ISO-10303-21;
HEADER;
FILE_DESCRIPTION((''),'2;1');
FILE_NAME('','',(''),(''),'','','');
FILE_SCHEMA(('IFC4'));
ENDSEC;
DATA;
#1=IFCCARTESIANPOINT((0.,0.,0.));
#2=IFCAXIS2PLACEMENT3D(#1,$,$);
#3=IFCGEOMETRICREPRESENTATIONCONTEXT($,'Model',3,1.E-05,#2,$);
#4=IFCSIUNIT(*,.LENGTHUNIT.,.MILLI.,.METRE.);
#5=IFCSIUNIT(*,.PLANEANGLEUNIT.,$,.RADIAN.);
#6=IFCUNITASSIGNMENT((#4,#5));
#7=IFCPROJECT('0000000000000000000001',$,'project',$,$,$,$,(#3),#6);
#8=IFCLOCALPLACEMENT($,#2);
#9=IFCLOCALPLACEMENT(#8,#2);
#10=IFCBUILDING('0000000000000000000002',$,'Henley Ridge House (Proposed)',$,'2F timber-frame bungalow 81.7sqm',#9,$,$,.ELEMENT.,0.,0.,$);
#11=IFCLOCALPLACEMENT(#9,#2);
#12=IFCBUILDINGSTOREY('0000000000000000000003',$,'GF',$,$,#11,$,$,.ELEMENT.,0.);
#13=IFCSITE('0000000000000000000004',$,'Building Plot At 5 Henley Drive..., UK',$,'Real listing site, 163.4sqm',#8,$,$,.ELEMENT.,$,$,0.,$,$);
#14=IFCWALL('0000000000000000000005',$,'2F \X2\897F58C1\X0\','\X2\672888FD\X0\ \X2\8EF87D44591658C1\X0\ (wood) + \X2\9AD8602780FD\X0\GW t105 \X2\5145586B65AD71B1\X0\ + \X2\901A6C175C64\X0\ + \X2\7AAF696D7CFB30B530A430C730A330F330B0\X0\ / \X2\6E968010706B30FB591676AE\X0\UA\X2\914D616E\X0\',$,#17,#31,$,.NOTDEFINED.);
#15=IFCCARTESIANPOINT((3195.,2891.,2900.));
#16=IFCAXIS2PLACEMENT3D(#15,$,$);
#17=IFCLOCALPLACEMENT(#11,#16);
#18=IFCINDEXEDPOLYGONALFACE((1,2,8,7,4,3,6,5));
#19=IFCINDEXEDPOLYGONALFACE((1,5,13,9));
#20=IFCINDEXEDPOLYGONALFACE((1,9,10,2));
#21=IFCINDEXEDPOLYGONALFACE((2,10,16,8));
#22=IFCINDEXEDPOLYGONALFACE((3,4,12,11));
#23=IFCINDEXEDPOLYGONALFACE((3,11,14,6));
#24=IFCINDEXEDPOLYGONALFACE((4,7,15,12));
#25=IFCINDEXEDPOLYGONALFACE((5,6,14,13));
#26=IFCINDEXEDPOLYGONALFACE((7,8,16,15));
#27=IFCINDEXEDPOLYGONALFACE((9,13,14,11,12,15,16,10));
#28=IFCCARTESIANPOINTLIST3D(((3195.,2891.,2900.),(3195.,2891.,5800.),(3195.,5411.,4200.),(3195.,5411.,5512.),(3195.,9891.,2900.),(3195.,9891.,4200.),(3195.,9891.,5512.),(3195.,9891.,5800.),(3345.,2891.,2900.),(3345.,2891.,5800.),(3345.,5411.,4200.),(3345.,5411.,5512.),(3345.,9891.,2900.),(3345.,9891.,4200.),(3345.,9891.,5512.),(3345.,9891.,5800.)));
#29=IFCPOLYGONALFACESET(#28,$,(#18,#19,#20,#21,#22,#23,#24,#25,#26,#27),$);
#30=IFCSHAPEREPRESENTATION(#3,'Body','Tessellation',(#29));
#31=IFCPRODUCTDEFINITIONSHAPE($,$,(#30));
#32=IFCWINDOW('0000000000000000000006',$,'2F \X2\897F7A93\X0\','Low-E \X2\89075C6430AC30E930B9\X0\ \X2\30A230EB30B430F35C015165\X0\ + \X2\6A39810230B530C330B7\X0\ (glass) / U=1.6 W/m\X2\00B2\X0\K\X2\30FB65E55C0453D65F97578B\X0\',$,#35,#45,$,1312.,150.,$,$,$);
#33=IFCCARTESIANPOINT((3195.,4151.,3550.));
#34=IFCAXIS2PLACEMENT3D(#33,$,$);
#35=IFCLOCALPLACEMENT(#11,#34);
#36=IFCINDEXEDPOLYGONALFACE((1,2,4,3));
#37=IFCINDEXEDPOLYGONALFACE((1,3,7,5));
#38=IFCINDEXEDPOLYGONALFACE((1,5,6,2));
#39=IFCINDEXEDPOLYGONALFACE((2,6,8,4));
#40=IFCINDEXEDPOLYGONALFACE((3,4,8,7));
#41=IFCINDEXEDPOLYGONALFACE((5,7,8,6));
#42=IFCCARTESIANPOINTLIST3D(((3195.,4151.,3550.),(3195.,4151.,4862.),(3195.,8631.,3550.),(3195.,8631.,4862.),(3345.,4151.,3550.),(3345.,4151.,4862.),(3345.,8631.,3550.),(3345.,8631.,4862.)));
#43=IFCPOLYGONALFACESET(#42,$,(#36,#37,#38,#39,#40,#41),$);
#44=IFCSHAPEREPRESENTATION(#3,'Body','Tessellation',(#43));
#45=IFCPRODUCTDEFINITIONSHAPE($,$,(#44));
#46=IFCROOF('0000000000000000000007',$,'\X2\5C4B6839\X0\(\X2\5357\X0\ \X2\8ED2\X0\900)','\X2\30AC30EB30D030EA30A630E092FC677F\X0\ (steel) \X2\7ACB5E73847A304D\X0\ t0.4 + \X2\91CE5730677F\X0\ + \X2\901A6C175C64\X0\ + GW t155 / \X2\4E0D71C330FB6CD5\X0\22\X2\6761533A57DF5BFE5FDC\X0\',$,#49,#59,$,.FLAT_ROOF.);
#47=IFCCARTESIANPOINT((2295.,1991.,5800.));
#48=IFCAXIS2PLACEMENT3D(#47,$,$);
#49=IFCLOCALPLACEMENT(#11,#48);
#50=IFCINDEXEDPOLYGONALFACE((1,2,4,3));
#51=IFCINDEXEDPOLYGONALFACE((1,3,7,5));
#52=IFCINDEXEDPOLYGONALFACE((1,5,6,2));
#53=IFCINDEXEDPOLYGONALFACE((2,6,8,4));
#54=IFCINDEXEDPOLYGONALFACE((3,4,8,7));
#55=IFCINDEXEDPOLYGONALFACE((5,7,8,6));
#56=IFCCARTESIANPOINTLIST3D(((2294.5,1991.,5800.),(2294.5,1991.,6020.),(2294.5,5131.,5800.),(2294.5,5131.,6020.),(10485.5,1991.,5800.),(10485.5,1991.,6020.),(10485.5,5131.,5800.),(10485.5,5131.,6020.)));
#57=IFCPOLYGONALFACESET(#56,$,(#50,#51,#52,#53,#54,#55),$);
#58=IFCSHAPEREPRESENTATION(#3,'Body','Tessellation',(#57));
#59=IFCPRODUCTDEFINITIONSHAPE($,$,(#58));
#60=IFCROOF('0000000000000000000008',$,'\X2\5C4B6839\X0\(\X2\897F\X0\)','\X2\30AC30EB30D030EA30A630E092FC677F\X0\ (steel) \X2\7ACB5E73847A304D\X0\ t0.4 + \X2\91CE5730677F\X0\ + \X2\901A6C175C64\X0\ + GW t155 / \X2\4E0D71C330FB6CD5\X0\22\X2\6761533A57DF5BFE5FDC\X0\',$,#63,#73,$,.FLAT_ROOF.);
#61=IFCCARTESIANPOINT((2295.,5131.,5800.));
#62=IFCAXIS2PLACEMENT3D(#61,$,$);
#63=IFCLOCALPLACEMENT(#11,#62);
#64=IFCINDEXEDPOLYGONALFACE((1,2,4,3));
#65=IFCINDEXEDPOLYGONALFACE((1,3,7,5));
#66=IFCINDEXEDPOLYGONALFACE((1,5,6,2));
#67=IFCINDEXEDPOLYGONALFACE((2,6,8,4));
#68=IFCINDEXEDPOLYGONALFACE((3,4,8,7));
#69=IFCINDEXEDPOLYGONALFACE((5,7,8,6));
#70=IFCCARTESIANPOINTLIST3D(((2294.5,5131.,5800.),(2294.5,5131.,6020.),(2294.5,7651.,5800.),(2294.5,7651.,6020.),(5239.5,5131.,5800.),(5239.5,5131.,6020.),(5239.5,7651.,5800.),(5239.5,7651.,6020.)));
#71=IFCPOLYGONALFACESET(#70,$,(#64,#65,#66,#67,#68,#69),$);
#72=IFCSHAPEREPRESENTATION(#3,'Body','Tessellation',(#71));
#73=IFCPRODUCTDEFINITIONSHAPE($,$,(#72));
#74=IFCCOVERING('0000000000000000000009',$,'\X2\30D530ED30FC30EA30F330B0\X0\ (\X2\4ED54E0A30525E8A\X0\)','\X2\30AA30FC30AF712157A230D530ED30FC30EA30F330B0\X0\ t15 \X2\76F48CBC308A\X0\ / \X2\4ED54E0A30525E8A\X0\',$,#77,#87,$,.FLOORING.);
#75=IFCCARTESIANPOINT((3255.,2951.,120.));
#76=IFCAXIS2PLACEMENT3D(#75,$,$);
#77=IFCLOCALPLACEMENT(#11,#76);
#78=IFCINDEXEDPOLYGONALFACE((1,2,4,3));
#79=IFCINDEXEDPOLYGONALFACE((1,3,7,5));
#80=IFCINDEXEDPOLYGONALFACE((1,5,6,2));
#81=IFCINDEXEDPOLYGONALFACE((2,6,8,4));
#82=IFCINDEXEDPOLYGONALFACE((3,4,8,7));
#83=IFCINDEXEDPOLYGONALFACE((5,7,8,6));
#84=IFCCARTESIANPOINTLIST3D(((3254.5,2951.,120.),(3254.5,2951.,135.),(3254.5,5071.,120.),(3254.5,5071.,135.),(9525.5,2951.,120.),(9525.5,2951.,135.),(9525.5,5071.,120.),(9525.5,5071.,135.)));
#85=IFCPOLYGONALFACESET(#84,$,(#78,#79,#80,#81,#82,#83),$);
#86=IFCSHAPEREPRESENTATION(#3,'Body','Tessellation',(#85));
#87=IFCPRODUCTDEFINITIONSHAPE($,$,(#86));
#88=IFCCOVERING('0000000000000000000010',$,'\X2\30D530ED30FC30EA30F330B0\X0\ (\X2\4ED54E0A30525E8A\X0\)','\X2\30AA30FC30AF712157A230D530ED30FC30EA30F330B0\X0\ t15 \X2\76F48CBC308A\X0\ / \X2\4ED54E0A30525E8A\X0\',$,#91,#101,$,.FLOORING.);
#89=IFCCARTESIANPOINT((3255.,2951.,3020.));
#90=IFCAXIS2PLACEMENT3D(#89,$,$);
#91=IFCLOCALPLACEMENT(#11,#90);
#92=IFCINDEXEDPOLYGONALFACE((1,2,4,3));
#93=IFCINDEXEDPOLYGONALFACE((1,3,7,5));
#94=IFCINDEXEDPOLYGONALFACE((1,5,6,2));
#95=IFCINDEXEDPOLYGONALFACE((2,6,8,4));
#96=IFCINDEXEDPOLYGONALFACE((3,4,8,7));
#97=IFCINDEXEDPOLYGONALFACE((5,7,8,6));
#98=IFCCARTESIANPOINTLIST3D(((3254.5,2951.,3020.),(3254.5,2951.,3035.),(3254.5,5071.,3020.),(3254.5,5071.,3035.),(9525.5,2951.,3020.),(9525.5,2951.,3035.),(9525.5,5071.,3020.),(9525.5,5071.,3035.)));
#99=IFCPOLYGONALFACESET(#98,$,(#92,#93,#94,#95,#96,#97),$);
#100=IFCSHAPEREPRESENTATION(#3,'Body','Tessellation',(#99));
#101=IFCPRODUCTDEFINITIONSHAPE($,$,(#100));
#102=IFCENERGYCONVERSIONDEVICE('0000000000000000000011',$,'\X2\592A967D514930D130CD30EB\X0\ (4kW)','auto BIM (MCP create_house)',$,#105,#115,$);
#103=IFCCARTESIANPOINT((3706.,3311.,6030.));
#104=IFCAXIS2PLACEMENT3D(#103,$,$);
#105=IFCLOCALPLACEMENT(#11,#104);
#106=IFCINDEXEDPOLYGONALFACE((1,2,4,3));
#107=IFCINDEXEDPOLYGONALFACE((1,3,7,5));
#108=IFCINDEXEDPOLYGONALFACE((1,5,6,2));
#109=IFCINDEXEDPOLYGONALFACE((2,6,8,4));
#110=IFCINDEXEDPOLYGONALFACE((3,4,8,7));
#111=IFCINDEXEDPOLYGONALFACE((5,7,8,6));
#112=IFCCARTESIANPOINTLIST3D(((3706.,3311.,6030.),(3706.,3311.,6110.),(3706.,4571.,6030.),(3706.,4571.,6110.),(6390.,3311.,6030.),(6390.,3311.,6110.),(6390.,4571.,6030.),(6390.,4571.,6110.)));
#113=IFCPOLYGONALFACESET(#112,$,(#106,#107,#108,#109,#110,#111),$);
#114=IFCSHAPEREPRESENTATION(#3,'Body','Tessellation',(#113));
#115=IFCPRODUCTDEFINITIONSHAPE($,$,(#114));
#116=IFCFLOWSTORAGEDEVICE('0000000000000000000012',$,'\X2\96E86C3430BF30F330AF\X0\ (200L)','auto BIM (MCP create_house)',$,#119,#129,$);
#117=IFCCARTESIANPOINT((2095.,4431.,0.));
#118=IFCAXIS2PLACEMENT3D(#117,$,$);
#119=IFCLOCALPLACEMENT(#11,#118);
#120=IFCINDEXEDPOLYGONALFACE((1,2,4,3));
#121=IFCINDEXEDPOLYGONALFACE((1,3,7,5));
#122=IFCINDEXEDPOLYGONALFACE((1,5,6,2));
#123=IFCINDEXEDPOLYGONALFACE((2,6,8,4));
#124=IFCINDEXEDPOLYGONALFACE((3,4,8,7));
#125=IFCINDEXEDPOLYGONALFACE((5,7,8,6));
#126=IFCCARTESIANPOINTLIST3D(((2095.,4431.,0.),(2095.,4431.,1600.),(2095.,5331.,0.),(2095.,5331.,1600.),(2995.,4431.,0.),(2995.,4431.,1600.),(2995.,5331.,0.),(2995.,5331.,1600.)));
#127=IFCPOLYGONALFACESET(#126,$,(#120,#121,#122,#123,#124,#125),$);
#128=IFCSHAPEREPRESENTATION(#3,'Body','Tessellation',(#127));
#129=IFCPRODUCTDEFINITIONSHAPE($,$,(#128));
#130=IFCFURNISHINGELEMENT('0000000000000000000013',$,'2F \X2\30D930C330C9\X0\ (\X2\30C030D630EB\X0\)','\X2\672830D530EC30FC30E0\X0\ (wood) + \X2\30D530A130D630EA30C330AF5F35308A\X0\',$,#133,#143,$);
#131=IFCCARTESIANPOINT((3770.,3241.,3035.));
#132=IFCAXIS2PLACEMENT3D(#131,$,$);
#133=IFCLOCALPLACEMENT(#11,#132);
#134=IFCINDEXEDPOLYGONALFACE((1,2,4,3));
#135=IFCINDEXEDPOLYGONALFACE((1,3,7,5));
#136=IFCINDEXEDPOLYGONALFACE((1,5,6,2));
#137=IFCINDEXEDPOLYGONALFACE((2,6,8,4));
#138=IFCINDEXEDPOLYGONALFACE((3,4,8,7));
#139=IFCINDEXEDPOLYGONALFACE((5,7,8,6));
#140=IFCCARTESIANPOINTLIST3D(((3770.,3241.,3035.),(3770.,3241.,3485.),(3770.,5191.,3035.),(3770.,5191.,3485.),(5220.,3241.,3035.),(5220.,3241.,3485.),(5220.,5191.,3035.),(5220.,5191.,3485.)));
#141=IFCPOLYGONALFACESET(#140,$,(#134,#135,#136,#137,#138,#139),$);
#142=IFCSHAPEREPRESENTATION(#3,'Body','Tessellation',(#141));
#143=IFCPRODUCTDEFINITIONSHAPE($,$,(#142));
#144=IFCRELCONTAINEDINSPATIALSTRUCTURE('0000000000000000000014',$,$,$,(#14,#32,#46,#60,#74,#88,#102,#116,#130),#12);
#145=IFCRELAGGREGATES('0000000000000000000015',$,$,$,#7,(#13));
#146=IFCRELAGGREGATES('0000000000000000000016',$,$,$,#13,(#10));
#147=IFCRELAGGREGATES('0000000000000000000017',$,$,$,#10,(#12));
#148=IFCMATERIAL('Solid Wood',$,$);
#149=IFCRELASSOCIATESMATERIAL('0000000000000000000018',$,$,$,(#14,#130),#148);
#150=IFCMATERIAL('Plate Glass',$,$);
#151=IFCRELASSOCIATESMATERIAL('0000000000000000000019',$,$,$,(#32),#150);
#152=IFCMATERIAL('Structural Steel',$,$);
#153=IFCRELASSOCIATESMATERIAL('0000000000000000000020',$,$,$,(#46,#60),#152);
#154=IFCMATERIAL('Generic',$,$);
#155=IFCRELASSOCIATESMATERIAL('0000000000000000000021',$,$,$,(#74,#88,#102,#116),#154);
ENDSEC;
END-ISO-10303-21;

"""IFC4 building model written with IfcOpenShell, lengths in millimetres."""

from ifc_helpers import new_model, si_unit, frame, frame_2d, origin, place, context, project, spatial, rectangle, extrude, material, element, fill, save


model = new_model("IFC4")

# Units and contexts
model_context = context("Model", 3, precision=1e-05, world=origin())
ifc_project = project(units=[si_unit("LENGTHUNIT", "METRE", prefix="MILLI"), si_unit("PLANEANGLEUNIT", "RADIAN")], contexts=[model_context])

# Site, building, storey
site_placement = place(None, origin())
site = spatial("IfcSite", under=ifc_project, at=site_placement, Name="Building Plot At 5 Henley Drive..., UK", ObjectType="Real listing site, 163.4sqm", CompositionType="ELEMENT", RefElevation=0.0)
building_placement = place(site_placement, origin())
building = spatial("IfcBuilding", under=site, at=building_placement, Name="Henley Ridge House (Proposed)", ObjectType="2F timber-frame bungalow 81.7sqm", CompositionType="ELEMENT", ElevationOfRefHeight=0.0, ElevationOfTerrain=0.0)
storey_placement = place(building_placement, origin())
storey = spatial("IfcBuildingStorey", under=building, at=storey_placement, Name="GF", CompositionType="ELEMENT", Elevation=0.0)

# Shared definitions
ifc_material_1 = material(Name="Solid Wood")

# Shared definitions
ifc_material_2 = material(Name="Plate Glass")

# Wall, opening, window
wall_1_placement = place(storey_placement, frame((3195.0, 2891.0, 2900.0)))
wall_1 = element("IfcWall", 1, at=wall_1_placement, inside=storey, material=ifc_material_1, Name="2F 西壁", Description="木製 軸組外壁 (wood) + 高性能GW t105 充填断熱 + 通気層 + 窯業系サイディング / 準耐火・外皮UA配慮", PredefinedType="NOTDEFINED", context=model_context, shape_type="SweptSolid", body=[
    extrude(rectangle(XDim=150.0, YDim=7000.0, at=frame_2d((75.0, 3500.0))), frame((3195.0, 2891.0, 2900.0)), (0.0, 0.0, 1.0), 2900.0),
])
opening_1_placement = place(storey_placement, frame((3195.0, 4151.0, 3550.0)))
opening_1 = element("IfcOpeningElement", 2, at=opening_1_placement, cuts=wall_1, PredefinedType="NOTDEFINED", context=model_context, shape_type="SweptSolid", body=[
    extrude(rectangle(XDim=150.0, YDim=4480.0, at=frame_2d((75.0, 2240.0))), frame((3195.0, 4151.0, 3550.0)), (0.0, 0.0, 1.0), 1312.0),
])
window_1_placement = place(storey_placement, frame((3195.0, 4151.0, 3550.0)))
window_1 = element("IfcWindow", 3, at=window_1_placement, inside=storey, material=ifc_material_2, Name="2F 西窓", Description="Low-E 複層ガラス アルゴン封入 + 樹脂サッシ (glass) / U=1.6 W/m²K・日射取得型", OverallHeight=1312.0, OverallWidth=150.0, context=model_context, shape_type="SweptSolid", body=[
    extrude(rectangle(XDim=150.0, YDim=4480.0, at=frame_2d((75.0, 2240.0))), frame((3195.0, 4151.0, 3550.0)), (0.0, 0.0, 1.0), 1312.0),
])
fill(opening_1, window_1)

# Roofs
ifc_material_3 = material(Name="Structural Steel")
roof_1_placement = place(storey_placement, frame((2295.0, 1991.0, 5800.0)))
element("IfcRoof", 4, at=roof_1_placement, inside=storey, material=ifc_material_3, Name="屋根(南 軒900)", Description="ガルバリウム鋼板 (steel) 立平葺き t0.4 + 野地板 + 通気層 + GW t155 / 不燃・法22条区域対応", PredefinedType="FLAT_ROOF", context=model_context, shape_type="SweptSolid", body=[
    extrude(rectangle(XDim=8191.0, YDim=3140.0, at=frame_2d((4095.0, 1570.0))), frame((2295.0, 1991.0, 5800.0)), (0.0, 0.0, 1.0), 220.0),
])
roof_2_placement = place(storey_placement, frame((2295.0, 5131.0, 5800.0)))
element("IfcRoof", 5, at=roof_2_placement, inside=storey, material=ifc_material_3, Name="屋根(西)", Description="ガルバリウム鋼板 (steel) 立平葺き t0.4 + 野地板 + 通気層 + GW t155 / 不燃・法22条区域対応", PredefinedType="FLAT_ROOF", context=model_context, shape_type="SweptSolid", body=[
    extrude(rectangle(XDim=2945.0, YDim=2520.0, at=frame_2d((1472.0, 1260.0))), frame((2295.0, 5131.0, 5800.0)), (0.0, 0.0, 1.0), 220.0),
])

# Coverings
ifc_material_4 = material(Name="Generic")
covering_1_placement = place(storey_placement, frame((3255.0, 2951.0, 120.0)))
element("IfcCovering", 6, at=covering_1_placement, inside=storey, material=ifc_material_4, Name="フローリング (仕上げ床)", Description="オーク無垢フローリング t15 直貼り / 仕上げ床", PredefinedType="FLOORING", context=model_context, shape_type="SweptSolid", body=[
    extrude(rectangle(XDim=6271.0, YDim=2120.0, at=frame_2d((3135.0, 1060.0))), frame((3255.0, 2951.0, 120.0)), (0.0, 0.0, 1.0), 15.0),
])
covering_2_placement = place(storey_placement, frame((3255.0, 2951.0, 3020.0)))
element("IfcCovering", 7, at=covering_2_placement, inside=storey, material=ifc_material_4, Name="フローリング (仕上げ床)", Description="オーク無垢フローリング t15 直貼り / 仕上げ床", PredefinedType="FLOORING", context=model_context, shape_type="SweptSolid", body=[
    extrude(rectangle(XDim=6271.0, YDim=2120.0, at=frame_2d((3135.0, 1060.0))), frame((3255.0, 2951.0, 3020.0)), (0.0, 0.0, 1.0), 15.0),
])

# Energy conversion device
energy_conversion_device_placement = place(storey_placement, frame((3706.0, 3311.0, 6030.0)))
element("IfcEnergyConversionDevice", 8, at=energy_conversion_device_placement, inside=storey, material=ifc_material_4, Name="太陽光パネル (4kW)", Description="auto BIM (MCP create_house)", context=model_context, shape_type="SweptSolid", body=[
    extrude(rectangle(XDim=2684.0, YDim=1260.0, at=frame_2d((1342.0, 630.0))), frame((3706.0, 3311.0, 6030.0)), (0.0, 0.0, 1.0), 80.0),
])

# Flow storage device
flow_storage_device_placement = place(storey_placement, frame((2095.0, 4431.0, 0.0)))
element("IfcFlowStorageDevice", 9, at=flow_storage_device_placement, inside=storey, material=ifc_material_4, Name="雨水タンク (200L)", Description="auto BIM (MCP create_house)", context=model_context, shape_type="SweptSolid", body=[
    extrude(rectangle(XDim=900.0, YDim=900.0, at=frame_2d((450.0, 450.0))), frame((2095.0, 4431.0, 0.0)), (0.0, 0.0, 1.0), 1600.0),
])

# Furnishing element
furnishing_placement = place(storey_placement, frame((3770.0, 3241.0, 3035.0)))
element("IfcFurnishingElement", 10, at=furnishing_placement, inside=storey, material=ifc_material_1, Name="2F ベッド (ダブル)", Description="木フレーム (wood) + ファブリック張り", context=model_context, shape_type="SweptSolid", body=[
    extrude(rectangle(XDim=1450.0, YDim=1950.0, at=frame_2d((725.0, 975.0))), frame((3770.0, 3241.0, 3035.0)), (0.0, 0.0, 1.0), 450.0),
])

save(model, "model.ifc")
